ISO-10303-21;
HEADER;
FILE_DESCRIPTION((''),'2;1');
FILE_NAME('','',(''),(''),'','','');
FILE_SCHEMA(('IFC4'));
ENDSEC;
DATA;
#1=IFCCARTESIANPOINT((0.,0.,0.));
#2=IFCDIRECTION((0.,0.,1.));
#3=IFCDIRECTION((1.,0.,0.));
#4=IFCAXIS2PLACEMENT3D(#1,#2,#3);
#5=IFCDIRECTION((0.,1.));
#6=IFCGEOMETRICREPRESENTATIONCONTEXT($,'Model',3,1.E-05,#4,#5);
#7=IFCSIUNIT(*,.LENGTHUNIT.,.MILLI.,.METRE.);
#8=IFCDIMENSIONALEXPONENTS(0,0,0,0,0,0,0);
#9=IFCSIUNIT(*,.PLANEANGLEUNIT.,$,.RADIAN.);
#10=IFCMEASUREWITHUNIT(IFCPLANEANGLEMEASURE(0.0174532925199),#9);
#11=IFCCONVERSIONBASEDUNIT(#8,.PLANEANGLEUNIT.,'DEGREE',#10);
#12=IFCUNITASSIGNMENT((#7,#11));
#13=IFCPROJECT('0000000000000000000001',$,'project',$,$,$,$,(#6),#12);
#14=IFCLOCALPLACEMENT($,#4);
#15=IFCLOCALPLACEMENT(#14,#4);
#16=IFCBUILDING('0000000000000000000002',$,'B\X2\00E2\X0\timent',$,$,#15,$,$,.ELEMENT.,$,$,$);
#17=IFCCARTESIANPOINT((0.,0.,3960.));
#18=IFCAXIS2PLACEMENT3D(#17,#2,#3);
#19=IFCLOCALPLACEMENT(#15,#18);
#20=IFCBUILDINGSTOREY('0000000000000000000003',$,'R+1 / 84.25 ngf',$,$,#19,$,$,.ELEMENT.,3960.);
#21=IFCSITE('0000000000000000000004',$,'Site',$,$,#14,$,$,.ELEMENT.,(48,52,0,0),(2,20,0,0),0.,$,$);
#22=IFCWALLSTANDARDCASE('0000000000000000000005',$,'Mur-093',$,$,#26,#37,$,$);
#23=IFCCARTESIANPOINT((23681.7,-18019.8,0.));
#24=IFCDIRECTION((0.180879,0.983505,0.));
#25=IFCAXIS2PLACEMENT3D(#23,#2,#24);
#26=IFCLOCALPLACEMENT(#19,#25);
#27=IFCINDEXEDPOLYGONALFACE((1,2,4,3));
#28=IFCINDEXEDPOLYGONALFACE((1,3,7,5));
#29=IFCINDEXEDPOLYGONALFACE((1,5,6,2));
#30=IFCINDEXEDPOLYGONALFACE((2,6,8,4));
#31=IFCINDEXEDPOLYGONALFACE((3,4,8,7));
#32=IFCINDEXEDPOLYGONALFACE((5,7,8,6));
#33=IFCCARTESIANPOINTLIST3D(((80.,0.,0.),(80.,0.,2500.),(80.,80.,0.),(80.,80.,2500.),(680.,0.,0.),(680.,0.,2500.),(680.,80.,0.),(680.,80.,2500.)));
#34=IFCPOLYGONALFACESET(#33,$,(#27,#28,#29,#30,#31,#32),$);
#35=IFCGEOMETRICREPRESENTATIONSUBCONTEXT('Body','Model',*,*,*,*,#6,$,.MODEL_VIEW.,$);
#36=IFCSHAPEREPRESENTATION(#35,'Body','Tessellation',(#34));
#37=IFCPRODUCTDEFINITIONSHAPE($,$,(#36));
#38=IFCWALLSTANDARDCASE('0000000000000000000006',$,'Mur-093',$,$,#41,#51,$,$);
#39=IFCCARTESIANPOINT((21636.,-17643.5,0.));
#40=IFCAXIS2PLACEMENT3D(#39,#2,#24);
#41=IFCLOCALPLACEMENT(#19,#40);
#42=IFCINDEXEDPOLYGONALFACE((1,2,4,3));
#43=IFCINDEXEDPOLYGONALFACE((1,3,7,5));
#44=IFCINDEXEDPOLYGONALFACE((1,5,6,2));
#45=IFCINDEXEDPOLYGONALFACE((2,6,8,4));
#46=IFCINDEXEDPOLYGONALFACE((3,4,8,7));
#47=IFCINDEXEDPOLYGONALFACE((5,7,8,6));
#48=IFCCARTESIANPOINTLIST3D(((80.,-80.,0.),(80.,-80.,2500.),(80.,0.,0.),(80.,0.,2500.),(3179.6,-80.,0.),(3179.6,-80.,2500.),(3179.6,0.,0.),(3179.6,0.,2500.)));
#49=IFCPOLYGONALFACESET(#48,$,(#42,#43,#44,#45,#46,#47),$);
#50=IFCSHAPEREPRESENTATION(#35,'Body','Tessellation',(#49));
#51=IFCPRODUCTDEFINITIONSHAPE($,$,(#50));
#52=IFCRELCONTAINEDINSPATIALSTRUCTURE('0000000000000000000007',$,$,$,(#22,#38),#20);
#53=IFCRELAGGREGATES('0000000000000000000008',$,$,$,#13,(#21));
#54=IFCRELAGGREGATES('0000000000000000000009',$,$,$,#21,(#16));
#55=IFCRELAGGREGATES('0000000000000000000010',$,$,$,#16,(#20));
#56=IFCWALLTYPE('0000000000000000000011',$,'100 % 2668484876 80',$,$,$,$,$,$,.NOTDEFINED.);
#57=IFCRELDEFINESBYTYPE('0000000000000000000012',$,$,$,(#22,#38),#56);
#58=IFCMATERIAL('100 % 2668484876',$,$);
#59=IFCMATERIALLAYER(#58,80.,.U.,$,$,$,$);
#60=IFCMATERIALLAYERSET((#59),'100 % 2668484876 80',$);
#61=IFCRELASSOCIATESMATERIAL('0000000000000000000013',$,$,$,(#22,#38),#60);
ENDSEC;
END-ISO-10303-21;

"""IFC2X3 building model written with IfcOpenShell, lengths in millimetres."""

from ifc_helpers import new_model, entity, si_unit, converted_unit, direction, frame, origin_with_axes, place, context, subcontext, project, spatial, polyline, outline, extrude, material, layer, layer_set, layer_usage, type_object, element, save


model = new_model("IFC2X3")

# Units and contexts
model_context = context("Model", 3, precision=1e-05, world=origin_with_axes(), true_north=direction((0.0, 1.0)))
body_context = subcontext(model_context, "Body", "Model", "MODEL_VIEW")
ifc_project = project(units=[si_unit("LENGTHUNIT", "METRE", prefix="MILLI"), converted_unit("PLANEANGLEUNIT", "DEGREE", entity("IfcPlaneAngleMeasure", 0.0174532925199), si_unit("PLANEANGLEUNIT", "RADIAN"), dimensions=[0, 0, 0, 0, 0, 0, 0])], contexts=[model_context])

# Site, building, storey
site_placement = place(None, origin_with_axes())
site = spatial("IfcSite", under=ifc_project, at=site_placement, Name="Site", CompositionType="ELEMENT", RefLatitude=(48, 52, 0, 0), RefLongitude=(2, 20, 0, 0), RefElevation=0.0)
building_placement = place(site_placement, origin_with_axes())
building = spatial("IfcBuilding", under=site, at=building_placement, Name="Bâtiment", CompositionType="ELEMENT")
storey_placement = place(building_placement, frame((0.0, 0.0, 3960.0), z_axis=(0.0, 0.0, 1.0), x_axis=(1.0, 0.0, 0.0)))
storey = spatial("IfcBuildingStorey", under=building, at=storey_placement, Name="R+1 / 84.25 ngf", CompositionType="ELEMENT", Elevation=3960.0)

# Wall
ifc_material_1 = material(Name="100 % 2668484876")
ifc_layer_1 = layer(ifc_material_1, 80.0, ventilated="UNKNOWN")
ifc_layer_set_1 = layer_set([ifc_layer_1], Name="100 % 2668484876 80")
ifc_layer_usage_1 = layer_usage(ifc_layer_set_1, "AXIS2", "NEGATIVE", 80.0)
wall_type_1 = type_object("IfcWallType", Name="100 % 2668484876 80", PredefinedType="NOTDEFINED")
wall_1_placement = place(storey_placement, frame((23681.7, -18019.8, 0.0), z_axis=(0.0, 0.0, 1.0), x_axis=(0.180879, 0.983505, 0.0)))
element("IfcWallStandardCase", 1, at=wall_1_placement, inside=storey, type_object=wall_type_1, material=ifc_layer_usage_1, Name="Mur-093", context=body_context, shape_type="SweptSolid", body=[
    extrude(outline(polyline([(80.0, 0.0), (680.0, 0.0), (680.0, 80.0), (80.0, 80.0), (80.0, 0.0)])), origin_with_axes(), (0.0, 0.0, 1.0), 2500.0),
])

# Wall
ifc_layer_usage_2 = layer_usage(ifc_layer_set_1, "AXIS2", "POSITIVE", -80.0)
wall_2_placement = place(storey_placement, frame((21636.0, -17643.5, 0.0), z_axis=(0.0, 0.0, 1.0), x_axis=(0.180879, 0.983505, 0.0)))
element("IfcWallStandardCase", 2, at=wall_2_placement, inside=storey, type_object=wall_type_1, material=ifc_layer_usage_2, Name="Mur-093", context=body_context, shape_type="SweptSolid", body=[
    extrude(outline(polyline([(80.0, -80.0), (3179.6, -80.0), (3179.6, 0.0), (80.0, 0.0), (80.0, -80.0)])), origin_with_axes(), (0.0, 0.0, 1.0), 2500.0),
])

save(model, "model.ifc")
